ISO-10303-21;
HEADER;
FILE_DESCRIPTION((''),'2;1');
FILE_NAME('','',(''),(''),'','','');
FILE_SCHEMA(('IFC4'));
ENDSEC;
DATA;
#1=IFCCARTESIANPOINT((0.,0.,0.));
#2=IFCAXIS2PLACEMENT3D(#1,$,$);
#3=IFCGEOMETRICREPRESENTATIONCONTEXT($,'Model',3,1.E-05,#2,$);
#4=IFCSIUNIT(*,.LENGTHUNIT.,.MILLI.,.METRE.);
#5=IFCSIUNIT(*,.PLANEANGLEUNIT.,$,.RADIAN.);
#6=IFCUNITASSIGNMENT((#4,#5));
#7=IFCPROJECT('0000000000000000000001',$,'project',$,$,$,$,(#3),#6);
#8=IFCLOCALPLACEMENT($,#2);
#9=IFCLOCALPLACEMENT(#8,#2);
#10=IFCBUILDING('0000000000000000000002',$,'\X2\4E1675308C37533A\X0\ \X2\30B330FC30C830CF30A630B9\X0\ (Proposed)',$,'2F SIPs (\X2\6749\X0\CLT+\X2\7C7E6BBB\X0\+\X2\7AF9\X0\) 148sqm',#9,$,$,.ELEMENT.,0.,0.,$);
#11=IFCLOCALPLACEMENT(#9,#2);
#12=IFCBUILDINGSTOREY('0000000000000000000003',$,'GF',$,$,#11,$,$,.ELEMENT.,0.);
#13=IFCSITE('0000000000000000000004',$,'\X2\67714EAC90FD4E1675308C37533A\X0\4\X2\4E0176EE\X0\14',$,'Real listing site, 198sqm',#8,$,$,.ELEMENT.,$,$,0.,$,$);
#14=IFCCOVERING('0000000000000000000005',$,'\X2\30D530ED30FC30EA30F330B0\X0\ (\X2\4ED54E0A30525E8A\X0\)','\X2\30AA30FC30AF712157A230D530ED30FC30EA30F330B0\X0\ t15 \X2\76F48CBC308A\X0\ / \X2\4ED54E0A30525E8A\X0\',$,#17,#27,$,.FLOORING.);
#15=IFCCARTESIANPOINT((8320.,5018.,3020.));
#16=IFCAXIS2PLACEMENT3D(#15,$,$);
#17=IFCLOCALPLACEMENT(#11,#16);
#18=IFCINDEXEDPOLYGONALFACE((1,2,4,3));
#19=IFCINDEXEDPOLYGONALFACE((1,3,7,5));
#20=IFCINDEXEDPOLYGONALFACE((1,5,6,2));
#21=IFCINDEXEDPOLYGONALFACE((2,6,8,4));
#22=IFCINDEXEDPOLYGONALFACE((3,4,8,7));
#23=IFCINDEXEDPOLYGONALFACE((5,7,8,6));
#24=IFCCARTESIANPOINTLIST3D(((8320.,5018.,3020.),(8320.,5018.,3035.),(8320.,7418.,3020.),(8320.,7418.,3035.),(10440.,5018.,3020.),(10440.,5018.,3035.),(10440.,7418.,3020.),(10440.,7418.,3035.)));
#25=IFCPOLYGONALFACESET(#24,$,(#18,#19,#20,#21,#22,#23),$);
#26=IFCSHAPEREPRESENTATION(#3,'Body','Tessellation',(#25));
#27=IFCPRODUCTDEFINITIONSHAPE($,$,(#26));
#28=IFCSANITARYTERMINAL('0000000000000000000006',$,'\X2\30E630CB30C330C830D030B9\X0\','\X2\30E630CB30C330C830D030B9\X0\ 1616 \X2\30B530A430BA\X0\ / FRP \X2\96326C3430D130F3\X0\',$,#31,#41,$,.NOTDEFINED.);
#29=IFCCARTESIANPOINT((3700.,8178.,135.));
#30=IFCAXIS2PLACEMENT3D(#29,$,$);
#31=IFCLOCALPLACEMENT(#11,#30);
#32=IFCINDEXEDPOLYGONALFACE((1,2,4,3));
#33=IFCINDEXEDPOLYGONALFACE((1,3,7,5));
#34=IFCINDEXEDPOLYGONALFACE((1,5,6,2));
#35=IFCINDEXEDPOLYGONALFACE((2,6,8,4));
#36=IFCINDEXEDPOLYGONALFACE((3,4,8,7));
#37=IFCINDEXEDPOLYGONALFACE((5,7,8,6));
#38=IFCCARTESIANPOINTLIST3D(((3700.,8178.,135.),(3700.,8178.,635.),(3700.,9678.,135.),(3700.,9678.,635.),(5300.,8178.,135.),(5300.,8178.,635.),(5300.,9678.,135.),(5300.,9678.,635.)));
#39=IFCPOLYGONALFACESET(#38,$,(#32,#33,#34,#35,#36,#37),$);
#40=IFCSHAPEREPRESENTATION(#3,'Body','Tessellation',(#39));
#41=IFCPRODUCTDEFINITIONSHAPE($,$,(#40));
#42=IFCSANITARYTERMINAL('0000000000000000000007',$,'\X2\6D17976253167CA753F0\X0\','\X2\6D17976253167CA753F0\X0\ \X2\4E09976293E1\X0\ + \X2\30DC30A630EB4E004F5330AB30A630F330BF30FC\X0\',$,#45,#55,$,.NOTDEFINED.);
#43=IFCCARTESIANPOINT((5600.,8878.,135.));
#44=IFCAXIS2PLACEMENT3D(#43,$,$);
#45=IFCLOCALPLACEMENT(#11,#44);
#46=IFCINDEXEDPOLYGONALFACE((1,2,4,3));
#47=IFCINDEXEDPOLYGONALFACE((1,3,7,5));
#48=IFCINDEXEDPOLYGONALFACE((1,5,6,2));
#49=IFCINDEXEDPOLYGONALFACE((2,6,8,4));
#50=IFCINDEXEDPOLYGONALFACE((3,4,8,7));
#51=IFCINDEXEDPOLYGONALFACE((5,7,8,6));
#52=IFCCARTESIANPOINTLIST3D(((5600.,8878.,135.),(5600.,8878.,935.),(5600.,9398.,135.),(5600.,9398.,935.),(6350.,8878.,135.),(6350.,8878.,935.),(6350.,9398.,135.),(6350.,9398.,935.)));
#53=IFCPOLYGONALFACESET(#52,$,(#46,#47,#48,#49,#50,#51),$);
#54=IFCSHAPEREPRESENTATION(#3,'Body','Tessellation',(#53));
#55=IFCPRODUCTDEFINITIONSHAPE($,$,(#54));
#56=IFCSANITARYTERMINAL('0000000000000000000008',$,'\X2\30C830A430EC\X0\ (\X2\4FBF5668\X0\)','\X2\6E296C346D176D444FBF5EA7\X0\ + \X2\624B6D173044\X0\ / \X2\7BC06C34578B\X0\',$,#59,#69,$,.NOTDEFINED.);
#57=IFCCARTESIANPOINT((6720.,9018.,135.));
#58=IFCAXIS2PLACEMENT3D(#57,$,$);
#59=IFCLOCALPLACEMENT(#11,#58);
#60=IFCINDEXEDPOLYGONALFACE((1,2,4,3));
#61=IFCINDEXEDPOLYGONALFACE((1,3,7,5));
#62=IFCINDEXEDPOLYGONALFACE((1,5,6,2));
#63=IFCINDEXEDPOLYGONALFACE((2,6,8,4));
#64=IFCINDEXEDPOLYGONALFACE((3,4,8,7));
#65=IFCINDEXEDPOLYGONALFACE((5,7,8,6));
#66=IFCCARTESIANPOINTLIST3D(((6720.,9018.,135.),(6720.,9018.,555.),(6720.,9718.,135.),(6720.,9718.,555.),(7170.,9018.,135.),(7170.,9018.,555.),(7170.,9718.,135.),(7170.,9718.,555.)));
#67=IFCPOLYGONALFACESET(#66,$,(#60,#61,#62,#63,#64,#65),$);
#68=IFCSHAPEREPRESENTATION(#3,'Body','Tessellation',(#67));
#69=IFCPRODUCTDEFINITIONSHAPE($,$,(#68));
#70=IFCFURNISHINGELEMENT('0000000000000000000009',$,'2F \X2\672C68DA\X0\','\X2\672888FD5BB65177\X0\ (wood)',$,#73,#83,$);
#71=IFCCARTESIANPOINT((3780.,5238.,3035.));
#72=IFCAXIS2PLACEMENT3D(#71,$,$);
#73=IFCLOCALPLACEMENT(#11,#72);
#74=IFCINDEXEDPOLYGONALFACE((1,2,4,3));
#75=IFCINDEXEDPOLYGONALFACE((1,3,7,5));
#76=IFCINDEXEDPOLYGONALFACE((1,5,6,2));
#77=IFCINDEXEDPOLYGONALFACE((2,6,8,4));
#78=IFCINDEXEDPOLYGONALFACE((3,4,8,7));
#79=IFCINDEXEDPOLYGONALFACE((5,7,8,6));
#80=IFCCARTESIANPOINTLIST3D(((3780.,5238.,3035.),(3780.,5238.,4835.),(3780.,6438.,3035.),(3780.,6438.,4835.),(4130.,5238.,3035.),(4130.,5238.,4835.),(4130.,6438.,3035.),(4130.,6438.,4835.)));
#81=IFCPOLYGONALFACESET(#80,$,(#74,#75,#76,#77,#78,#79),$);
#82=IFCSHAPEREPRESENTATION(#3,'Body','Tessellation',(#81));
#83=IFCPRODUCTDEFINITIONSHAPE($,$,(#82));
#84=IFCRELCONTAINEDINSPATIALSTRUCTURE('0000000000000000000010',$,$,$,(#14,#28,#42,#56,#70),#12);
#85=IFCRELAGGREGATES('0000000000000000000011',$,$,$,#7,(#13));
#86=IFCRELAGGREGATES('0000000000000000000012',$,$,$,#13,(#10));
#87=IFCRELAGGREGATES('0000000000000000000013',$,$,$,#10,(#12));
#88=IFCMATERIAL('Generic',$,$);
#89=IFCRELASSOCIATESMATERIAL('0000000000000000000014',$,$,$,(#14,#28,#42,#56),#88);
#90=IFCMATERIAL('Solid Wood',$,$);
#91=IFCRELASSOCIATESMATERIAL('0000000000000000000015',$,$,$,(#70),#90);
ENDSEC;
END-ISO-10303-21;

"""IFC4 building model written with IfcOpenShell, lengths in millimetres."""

from ifc_helpers import new_model, si_unit, frame, frame_2d, origin, place, context, project, spatial, rectangle, extrude, material, element, save


model = new_model("IFC4")

# Units and contexts
model_context = context("Model", 3, precision=1e-05, world=origin())
ifc_project = project(units=[si_unit("LENGTHUNIT", "METRE", prefix="MILLI"), si_unit("PLANEANGLEUNIT", "RADIAN")], contexts=[model_context])

# Site, building, storey
site_placement = place(None, origin())
site = spatial("IfcSite", under=ifc_project, at=site_placement, Name="東京都世田谷区4丁目14", ObjectType="Real listing site, 198sqm", CompositionType="ELEMENT", RefElevation=0.0)
building_placement = place(site_placement, origin())
building = spatial("IfcBuilding", under=site, at=building_placement, Name="世田谷区 コートハウス (Proposed)", ObjectType="2F SIPs (杉CLT+籾殻+竹) 148sqm", CompositionType="ELEMENT", ElevationOfRefHeight=0.0, ElevationOfTerrain=0.0)
storey_placement = place(building_placement, origin())
storey = spatial("IfcBuildingStorey", under=building, at=storey_placement, Name="GF", CompositionType="ELEMENT", Elevation=0.0)

# Shared definitions
ifc_material_1 = material(Name="Solid Wood")
ifc_material_2 = material(Name="Generic")

# Covering
covering_1_placement = place(storey_placement, frame((8320.0, 5018.0, 3020.0)))
element("IfcCovering", 1, at=covering_1_placement, inside=storey, material=ifc_material_2, Name="フローリング (仕上げ床)", Description="オーク無垢フローリング t15 直貼り / 仕上げ床", PredefinedType="FLOORING", context=model_context, shape_type="SweptSolid", body=[
    extrude(rectangle(XDim=2120.0, YDim=2400.0, at=frame_2d((1060.0, 1200.0))), frame((8320.0, 5018.0, 3020.0)), (0.0, 0.0, 1.0), 15.0),
])

# Sanitary terminals
sanitary_terminal_1_placement = place(storey_placement, frame((3700.0, 8178.0, 135.0)))
element("IfcSanitaryTerminal", 2, at=sanitary_terminal_1_placement, inside=storey, material=ifc_material_2, Name="ユニットバス", Description="ユニットバス 1616 サイズ / FRP 防水パン", PredefinedType="NOTDEFINED", context=model_context, shape_type="SweptSolid", body=[
    extrude(rectangle(XDim=1600.0, YDim=1500.0, at=frame_2d((800.0, 750.0))), frame((3700.0, 8178.0, 135.0)), (0.0, 0.0, 1.0), 500.0),
])
sanitary_terminal_2_placement = place(storey_placement, frame((5600.0, 8878.0, 135.0)))
element("IfcSanitaryTerminal", 3, at=sanitary_terminal_2_placement, inside=storey, material=ifc_material_2, Name="洗面化粧台", Description="洗面化粧台 三面鏡 + ボウル一体カウンター", PredefinedType="NOTDEFINED", context=model_context, shape_type="SweptSolid", body=[
    extrude(rectangle(XDim=750.0, YDim=520.0, at=frame_2d((375.0, 260.0))), frame((5600.0, 8878.0, 135.0)), (0.0, 0.0, 1.0), 800.0),
])
sanitary_terminal_3_placement = place(storey_placement, frame((6720.0, 9018.0, 135.0)))
element("IfcSanitaryTerminal", 4, at=sanitary_terminal_3_placement, inside=storey, material=ifc_material_2, Name="トイレ (便器)", Description="温水洗浄便座 + 手洗い / 節水型", PredefinedType="NOTDEFINED", context=model_context, shape_type="SweptSolid", body=[
    extrude(rectangle(XDim=450.0, YDim=700.0, at=frame_2d((225.0, 350.0))), frame((6720.0, 9018.0, 135.0)), (0.0, 0.0, 1.0), 420.0),
])

# Furnishing element
furnishing_placement = place(storey_placement, frame((3780.0, 5238.0, 3035.0)))
element("IfcFurnishingElement", 5, at=furnishing_placement, inside=storey, material=ifc_material_1, Name="2F 本棚", Description="木製家具 (wood)", context=model_context, shape_type="SweptSolid", body=[
    extrude(rectangle(XDim=350.0, YDim=1200.0, at=frame_2d((175.0, 600.0))), frame((3780.0, 5238.0, 3035.0)), (0.0, 0.0, 1.0), 1800.0),
])

save(model, "model.ifc")
